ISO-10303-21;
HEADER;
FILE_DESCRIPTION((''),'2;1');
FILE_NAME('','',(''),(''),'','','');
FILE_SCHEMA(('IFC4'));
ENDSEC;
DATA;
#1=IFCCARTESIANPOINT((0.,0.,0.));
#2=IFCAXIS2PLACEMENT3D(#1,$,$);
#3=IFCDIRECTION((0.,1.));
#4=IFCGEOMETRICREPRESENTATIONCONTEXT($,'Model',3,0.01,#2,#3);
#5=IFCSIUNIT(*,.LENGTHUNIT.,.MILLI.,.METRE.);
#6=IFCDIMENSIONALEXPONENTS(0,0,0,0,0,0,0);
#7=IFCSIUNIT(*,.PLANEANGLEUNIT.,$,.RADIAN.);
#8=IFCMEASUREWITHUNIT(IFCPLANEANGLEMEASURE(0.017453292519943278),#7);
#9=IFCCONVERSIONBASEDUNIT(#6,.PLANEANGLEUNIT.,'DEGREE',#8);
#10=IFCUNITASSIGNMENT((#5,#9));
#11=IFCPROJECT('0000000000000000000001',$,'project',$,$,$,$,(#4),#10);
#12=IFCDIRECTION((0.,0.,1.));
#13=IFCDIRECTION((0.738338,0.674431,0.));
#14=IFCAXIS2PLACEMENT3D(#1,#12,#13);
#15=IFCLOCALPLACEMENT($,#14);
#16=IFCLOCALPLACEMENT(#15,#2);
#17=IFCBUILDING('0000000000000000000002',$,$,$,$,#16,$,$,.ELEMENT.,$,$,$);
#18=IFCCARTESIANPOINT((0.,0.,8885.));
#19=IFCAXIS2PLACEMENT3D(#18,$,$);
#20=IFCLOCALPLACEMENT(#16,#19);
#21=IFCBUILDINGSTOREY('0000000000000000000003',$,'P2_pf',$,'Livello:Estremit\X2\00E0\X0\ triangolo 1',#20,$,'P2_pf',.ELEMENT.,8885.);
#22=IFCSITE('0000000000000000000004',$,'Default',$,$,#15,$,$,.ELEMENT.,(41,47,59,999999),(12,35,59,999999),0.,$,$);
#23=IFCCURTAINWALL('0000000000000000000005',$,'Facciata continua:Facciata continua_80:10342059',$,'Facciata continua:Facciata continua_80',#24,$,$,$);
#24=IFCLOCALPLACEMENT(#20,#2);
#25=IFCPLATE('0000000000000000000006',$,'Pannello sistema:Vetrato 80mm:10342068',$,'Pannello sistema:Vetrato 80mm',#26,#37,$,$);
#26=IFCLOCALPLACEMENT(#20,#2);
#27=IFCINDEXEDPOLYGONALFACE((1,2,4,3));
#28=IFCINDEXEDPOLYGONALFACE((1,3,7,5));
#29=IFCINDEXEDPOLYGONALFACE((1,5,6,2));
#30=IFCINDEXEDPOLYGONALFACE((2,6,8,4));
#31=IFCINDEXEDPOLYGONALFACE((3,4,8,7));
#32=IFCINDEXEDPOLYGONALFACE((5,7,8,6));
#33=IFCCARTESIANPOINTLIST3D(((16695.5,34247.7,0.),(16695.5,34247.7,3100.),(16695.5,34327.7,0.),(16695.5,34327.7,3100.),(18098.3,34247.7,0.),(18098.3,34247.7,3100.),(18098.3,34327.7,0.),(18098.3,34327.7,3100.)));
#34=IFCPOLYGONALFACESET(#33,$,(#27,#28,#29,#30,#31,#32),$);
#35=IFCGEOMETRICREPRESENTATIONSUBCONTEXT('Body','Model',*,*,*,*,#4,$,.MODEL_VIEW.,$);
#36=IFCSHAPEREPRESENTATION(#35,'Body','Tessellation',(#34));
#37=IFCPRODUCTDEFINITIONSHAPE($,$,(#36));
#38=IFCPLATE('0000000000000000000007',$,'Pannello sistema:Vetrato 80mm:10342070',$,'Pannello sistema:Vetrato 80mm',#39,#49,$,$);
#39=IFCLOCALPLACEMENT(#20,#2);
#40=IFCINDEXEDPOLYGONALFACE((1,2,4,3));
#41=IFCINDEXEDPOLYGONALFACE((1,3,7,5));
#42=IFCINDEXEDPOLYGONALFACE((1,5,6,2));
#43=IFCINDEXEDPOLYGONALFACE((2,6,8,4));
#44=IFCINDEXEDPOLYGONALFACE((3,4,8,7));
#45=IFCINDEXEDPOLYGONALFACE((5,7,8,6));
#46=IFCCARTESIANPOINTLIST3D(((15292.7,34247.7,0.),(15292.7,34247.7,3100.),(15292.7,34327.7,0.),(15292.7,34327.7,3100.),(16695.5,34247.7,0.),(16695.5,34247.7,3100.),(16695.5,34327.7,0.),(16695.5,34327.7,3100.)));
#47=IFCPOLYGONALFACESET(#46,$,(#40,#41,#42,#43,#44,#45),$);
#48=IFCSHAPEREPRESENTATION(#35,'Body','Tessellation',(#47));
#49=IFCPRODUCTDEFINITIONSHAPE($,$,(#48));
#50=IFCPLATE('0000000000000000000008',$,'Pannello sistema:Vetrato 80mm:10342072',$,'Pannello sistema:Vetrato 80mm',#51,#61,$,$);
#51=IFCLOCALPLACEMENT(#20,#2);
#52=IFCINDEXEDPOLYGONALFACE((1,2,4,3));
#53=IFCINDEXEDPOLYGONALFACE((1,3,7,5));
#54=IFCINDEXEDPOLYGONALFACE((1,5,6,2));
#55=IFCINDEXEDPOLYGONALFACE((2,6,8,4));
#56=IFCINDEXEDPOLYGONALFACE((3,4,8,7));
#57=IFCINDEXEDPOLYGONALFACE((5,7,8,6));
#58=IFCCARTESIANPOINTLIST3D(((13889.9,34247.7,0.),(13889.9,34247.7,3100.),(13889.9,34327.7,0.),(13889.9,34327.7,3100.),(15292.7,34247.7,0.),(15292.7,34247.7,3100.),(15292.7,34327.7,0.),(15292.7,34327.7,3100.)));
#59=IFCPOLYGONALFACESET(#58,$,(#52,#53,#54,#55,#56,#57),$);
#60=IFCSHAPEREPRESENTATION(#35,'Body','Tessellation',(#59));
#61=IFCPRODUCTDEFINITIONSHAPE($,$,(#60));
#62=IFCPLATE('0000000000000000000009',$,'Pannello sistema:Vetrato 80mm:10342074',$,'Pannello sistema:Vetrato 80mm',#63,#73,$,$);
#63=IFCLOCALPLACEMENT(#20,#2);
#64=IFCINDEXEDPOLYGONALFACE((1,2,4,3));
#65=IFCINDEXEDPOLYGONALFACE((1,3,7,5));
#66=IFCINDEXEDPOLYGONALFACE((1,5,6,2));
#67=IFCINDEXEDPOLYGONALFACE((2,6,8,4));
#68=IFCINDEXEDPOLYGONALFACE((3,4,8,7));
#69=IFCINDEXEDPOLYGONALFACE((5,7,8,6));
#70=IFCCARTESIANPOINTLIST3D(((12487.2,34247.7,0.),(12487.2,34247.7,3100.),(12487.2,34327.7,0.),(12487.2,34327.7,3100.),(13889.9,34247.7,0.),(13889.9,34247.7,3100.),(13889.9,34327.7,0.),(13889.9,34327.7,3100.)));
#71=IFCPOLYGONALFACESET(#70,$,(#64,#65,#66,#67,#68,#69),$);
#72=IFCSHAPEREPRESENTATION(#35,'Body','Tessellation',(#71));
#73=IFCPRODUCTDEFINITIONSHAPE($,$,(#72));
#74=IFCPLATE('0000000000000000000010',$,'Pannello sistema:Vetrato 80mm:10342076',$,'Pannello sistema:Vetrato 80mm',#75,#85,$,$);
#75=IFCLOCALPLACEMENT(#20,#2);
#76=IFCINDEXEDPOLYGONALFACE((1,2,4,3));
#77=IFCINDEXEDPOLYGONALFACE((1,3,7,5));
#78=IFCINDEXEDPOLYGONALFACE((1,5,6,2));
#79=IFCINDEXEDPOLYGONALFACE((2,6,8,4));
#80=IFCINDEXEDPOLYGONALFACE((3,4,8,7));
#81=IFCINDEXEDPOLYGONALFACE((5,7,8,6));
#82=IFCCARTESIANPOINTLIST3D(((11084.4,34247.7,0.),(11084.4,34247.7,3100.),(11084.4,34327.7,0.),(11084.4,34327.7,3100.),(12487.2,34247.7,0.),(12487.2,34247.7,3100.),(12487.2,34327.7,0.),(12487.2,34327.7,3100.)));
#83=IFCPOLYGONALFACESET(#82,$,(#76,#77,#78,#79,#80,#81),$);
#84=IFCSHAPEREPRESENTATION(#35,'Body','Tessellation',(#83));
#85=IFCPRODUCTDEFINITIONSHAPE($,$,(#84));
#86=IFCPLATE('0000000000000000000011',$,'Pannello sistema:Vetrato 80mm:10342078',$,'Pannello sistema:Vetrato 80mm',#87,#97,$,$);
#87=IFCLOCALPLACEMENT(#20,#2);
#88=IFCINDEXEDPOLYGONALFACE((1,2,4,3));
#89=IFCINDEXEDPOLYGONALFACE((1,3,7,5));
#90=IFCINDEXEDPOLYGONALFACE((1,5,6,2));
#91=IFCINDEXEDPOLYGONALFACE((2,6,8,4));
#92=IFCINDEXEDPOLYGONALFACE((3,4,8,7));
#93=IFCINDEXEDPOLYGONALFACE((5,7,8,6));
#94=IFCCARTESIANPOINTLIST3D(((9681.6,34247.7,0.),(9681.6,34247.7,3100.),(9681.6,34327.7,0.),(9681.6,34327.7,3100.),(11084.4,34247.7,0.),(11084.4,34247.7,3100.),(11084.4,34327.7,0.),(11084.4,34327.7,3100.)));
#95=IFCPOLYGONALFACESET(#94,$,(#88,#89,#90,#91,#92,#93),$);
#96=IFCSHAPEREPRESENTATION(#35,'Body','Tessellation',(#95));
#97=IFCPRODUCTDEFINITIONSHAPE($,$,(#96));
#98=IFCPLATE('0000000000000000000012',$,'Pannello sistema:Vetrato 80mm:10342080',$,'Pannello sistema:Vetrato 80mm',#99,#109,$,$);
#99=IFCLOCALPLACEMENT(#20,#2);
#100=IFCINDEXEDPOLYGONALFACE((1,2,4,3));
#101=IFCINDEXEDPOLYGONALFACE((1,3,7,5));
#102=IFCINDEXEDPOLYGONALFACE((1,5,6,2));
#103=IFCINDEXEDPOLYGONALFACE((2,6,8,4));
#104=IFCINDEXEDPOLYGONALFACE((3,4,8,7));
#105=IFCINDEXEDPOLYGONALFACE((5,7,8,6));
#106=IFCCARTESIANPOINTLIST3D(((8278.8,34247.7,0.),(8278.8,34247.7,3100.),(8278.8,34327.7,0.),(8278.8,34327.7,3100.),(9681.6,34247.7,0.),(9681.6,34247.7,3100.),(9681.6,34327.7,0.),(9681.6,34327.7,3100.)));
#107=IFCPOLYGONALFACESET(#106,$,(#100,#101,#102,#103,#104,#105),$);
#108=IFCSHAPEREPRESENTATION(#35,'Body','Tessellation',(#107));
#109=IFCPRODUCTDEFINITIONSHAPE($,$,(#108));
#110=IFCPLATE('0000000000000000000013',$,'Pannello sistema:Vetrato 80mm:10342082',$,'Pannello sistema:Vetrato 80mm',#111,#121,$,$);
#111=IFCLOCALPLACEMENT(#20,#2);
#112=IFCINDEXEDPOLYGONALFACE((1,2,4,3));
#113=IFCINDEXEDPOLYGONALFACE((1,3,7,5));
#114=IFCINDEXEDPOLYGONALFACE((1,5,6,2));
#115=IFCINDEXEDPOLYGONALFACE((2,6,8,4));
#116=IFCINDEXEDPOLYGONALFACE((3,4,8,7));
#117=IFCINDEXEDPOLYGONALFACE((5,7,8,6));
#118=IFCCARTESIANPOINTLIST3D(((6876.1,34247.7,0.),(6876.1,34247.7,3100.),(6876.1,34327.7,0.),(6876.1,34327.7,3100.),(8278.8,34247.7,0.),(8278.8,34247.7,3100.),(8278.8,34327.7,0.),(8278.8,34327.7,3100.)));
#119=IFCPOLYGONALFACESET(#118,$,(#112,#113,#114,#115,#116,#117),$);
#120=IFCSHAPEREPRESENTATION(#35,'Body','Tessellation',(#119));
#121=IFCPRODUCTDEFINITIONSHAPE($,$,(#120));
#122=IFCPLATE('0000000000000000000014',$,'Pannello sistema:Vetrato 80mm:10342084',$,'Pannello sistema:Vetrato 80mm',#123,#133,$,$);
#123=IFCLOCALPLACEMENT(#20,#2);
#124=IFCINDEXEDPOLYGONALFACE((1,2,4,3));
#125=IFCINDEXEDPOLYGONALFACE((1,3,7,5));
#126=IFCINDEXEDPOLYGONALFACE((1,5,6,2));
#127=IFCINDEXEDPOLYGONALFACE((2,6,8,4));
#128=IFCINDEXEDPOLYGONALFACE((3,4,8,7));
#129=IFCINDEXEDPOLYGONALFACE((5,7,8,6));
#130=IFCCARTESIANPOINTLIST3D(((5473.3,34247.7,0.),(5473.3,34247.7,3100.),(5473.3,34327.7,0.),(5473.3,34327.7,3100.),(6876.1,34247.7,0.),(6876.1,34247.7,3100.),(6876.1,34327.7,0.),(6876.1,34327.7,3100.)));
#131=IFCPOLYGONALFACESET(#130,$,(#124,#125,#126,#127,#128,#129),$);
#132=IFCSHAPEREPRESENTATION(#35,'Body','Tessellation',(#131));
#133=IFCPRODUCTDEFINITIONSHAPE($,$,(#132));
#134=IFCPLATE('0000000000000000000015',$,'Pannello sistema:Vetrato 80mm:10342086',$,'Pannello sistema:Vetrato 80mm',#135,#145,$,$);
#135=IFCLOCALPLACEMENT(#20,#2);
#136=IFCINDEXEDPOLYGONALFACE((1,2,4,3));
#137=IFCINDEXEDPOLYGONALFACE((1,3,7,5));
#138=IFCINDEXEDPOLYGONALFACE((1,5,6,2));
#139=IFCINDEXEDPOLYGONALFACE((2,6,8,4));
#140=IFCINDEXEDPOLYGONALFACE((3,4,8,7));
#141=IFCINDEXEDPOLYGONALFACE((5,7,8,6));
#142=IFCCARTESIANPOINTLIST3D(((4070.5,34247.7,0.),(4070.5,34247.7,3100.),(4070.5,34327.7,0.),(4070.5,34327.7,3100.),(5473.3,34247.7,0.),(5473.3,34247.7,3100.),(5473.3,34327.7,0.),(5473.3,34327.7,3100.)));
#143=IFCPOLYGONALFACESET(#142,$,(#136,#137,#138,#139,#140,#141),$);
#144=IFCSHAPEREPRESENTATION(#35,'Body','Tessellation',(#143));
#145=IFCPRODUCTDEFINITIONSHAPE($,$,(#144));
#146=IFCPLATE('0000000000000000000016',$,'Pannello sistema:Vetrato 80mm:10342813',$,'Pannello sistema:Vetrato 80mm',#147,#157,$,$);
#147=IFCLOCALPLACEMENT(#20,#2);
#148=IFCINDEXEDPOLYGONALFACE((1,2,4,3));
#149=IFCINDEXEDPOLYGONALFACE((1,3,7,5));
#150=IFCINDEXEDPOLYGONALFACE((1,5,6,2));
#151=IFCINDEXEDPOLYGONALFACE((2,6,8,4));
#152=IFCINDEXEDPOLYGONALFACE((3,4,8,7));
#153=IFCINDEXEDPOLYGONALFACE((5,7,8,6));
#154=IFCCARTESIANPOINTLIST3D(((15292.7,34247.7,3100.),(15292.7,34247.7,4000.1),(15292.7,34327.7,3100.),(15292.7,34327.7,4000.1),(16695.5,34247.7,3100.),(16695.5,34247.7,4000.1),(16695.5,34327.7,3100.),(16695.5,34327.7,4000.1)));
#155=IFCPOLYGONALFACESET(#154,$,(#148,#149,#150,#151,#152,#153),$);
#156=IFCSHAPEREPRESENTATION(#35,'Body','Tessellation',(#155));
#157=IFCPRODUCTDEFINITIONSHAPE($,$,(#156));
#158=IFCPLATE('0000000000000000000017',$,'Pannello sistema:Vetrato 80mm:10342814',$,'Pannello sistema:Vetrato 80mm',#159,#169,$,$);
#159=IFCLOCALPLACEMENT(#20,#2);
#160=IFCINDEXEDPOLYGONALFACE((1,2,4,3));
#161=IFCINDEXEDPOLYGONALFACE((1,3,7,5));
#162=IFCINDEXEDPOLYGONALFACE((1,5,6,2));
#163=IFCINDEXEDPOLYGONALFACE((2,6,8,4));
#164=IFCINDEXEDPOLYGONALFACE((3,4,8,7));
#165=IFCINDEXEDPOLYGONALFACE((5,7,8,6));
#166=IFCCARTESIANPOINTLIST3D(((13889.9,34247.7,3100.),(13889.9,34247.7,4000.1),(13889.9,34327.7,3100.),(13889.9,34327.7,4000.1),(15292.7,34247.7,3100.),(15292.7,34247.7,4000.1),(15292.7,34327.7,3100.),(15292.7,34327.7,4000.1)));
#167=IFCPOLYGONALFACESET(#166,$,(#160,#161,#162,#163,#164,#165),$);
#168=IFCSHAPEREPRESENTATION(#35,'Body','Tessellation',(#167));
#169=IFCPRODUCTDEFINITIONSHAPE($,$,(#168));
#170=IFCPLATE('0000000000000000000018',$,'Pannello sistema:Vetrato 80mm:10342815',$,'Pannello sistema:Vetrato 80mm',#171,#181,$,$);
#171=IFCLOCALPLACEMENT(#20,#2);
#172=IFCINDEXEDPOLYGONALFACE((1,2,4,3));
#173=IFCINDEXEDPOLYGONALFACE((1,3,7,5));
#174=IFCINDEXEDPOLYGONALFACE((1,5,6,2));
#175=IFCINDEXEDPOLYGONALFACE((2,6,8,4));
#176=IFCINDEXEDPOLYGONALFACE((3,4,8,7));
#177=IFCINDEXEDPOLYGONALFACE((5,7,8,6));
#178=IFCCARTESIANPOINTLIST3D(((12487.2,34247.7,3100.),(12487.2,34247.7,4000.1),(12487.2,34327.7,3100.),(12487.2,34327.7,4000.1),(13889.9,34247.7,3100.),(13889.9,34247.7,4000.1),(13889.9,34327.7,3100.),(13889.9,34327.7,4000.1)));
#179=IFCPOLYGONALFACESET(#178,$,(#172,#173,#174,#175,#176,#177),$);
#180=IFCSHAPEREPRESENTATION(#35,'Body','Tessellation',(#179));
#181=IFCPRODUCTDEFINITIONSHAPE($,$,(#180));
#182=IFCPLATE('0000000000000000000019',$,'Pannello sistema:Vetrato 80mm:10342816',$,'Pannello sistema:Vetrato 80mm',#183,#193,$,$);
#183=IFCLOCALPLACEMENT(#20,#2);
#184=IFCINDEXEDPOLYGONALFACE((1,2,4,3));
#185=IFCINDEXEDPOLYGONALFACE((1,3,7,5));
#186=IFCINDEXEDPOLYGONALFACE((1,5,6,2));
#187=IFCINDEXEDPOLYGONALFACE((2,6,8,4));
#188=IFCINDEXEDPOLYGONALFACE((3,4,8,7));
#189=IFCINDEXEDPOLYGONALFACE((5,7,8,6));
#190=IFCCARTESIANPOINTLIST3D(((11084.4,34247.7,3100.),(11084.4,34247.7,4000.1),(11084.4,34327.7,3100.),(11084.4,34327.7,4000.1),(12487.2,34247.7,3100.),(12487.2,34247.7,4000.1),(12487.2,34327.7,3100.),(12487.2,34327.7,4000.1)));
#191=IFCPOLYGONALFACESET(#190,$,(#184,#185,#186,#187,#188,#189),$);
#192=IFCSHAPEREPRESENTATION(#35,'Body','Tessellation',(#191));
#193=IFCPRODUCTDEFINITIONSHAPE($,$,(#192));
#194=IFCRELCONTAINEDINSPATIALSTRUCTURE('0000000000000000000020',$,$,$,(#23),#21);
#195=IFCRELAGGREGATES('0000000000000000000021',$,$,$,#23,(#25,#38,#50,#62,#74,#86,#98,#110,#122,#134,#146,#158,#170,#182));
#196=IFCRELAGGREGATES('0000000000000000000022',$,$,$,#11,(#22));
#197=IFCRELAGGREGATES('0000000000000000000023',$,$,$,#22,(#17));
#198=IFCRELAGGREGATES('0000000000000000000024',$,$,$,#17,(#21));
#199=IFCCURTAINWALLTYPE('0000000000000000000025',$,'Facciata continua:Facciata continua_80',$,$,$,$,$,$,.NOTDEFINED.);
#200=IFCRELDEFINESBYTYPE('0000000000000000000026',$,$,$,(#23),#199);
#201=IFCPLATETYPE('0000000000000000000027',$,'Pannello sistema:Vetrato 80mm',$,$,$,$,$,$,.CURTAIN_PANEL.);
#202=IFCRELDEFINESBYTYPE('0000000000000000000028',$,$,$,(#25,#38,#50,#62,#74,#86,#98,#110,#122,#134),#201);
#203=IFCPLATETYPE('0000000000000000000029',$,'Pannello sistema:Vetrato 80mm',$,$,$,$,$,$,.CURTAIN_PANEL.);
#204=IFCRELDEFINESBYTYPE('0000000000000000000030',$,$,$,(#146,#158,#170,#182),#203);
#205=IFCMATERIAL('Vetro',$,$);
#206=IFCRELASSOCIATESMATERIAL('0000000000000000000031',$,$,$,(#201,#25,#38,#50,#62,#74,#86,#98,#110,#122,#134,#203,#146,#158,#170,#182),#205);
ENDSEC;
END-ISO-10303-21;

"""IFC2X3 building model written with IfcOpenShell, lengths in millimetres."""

from ifc_helpers import new_model, entity, si_unit, converted_unit, direction, frame, origin, origin_2d_with_axis, place, context, subcontext, project, spatial, rectangle, extrude, source, transform, mapped, material, type_object, type_shapes, element, aggregate, save


model = new_model("IFC2X3")

# Units and contexts
model_context = context("Model", 3, precision=0.01, world=origin(), true_north=direction((0.0, 1.0)))
body_context = subcontext(model_context, "Body", "Model", "MODEL_VIEW")
ifc_project = project(units=[si_unit("LENGTHUNIT", "METRE", prefix="MILLI"), converted_unit("PLANEANGLEUNIT", "DEGREE", entity("IfcPlaneAngleMeasure", 0.017453292519943278), si_unit("PLANEANGLEUNIT", "RADIAN"), dimensions=[0, 0, 0, 0, 0, 0, 0])], contexts=[model_context])

# Site, building, storey
site_placement = place(None, frame((0.0, 0.0, 0.0), z_axis=(0.0, 0.0, 1.0), x_axis=(0.738338, 0.674431, 0.0)))
site = spatial("IfcSite", under=ifc_project, at=site_placement, Name="Default", CompositionType="ELEMENT", RefLatitude=(41, 47, 59, 999999), RefLongitude=(12, 35, 59, 999999), RefElevation=0.0)
building_placement = place(site_placement, origin())
building = spatial("IfcBuilding", under=site, at=building_placement, CompositionType="ELEMENT")
storey_placement = place(building_placement, frame((0.0, 0.0, 8885.0)))
storey = spatial("IfcBuildingStorey", under=building, at=storey_placement, Name="P2_pf", ObjectType="Livello:Estremità triangolo 1", LongName="P2_pf", CompositionType="ELEMENT", Elevation=8885.0)

# Curtain wall, plates
curtain_wall_type = type_object("IfcCurtainWallType", Name="Facciata continua:Facciata continua_80", PredefinedType="NOTDEFINED")
curtain_wall_1_placement = place(storey_placement, frame((0.0, 0.0, -8885.0)))
curtain_wall_1 = element("IfcCurtainWall", 1, at=curtain_wall_1_placement, inside=storey, type_object=curtain_wall_type, Name="Facciata continua:Facciata continua_80:10342059", ObjectType="Facciata continua:Facciata continua_80")
ifc_material_1 = material(Name="Vetro")
plate_type_1 = type_object("IfcPlateType", Name="Pannello sistema:Vetrato 80mm", PredefinedType="CURTAIN_PANEL", material=ifc_material_1)
shared_shape_1 = source(origin(), body_context, "Body", "SweptSolid", [
    extrude(rectangle(XDim=80.0, YDim=1402.8, at=origin_2d_with_axis()), frame((0.0, -40.0, 0.0), z_axis=(0.0, 0.0, 1.0), x_axis=(0.0, 1.0, 0.0)), (0.0, 0.0, 1.0), 3100.0),
])
type_shapes(plate_type_1, [shared_shape_1])
plate_1_placement = place(curtain_wall_1_placement, frame((17396.9, 34247.7, 8885.0), z_axis=(0.0, 0.0, 1.0), x_axis=(-1.0, 0.0, 0.0)))
plate_1 = element("IfcPlate", 2, at=plate_1_placement, type_object=plate_type_1, material=ifc_material_1, Name="Pannello sistema:Vetrato 80mm:10342068", ObjectType="Pannello sistema:Vetrato 80mm", context=body_context, shape_type="MappedRepresentation", body=[
    mapped(shared_shape_1, transform((0.0, 0.0, 0.0), scale=1.0)),
])
plate_2_placement = place(curtain_wall_1_placement, frame((15994.1, 34247.7, 8885.0), z_axis=(0.0, 0.0, 1.0), x_axis=(-1.0, 0.0, 0.0)))
plate_2 = element("IfcPlate", 3, at=plate_2_placement, type_object=plate_type_1, material=ifc_material_1, Name="Pannello sistema:Vetrato 80mm:10342070", ObjectType="Pannello sistema:Vetrato 80mm", context=body_context, shape_type="MappedRepresentation", body=[
    mapped(shared_shape_1, transform((0.0, 0.0, 0.0), scale=1.0)),
])
plate_3_placement = place(curtain_wall_1_placement, frame((14591.3, 34247.7, 8885.0), z_axis=(0.0, 0.0, 1.0), x_axis=(-1.0, 0.0, 0.0)))
plate_3 = element("IfcPlate", 4, at=plate_3_placement, type_object=plate_type_1, material=ifc_material_1, Name="Pannello sistema:Vetrato 80mm:10342072", ObjectType="Pannello sistema:Vetrato 80mm", context=body_context, shape_type="MappedRepresentation", body=[
    mapped(shared_shape_1, transform((0.0, 0.0, 0.0), scale=1.0)),
])
plate_4_placement = place(curtain_wall_1_placement, frame((13188.5, 34247.7, 8885.0), z_axis=(0.0, 0.0, 1.0), x_axis=(-1.0, 0.0, 0.0)))
plate_4 = element("IfcPlate", 5, at=plate_4_placement, type_object=plate_type_1, material=ifc_material_1, Name="Pannello sistema:Vetrato 80mm:10342074", ObjectType="Pannello sistema:Vetrato 80mm", context=body_context, shape_type="MappedRepresentation", body=[
    mapped(shared_shape_1, transform((0.0, 0.0, 0.0), scale=1.0)),
])
plate_5_placement = place(curtain_wall_1_placement, frame((11785.8, 34247.7, 8885.0), z_axis=(0.0, 0.0, 1.0), x_axis=(-1.0, 0.0, 0.0)))
plate_5 = element("IfcPlate", 6, at=plate_5_placement, type_object=plate_type_1, material=ifc_material_1, Name="Pannello sistema:Vetrato 80mm:10342076", ObjectType="Pannello sistema:Vetrato 80mm", context=body_context, shape_type="MappedRepresentation", body=[
    mapped(shared_shape_1, transform((0.0, 0.0, 0.0), scale=1.0)),
])
plate_6_placement = place(curtain_wall_1_placement, frame((10383.0, 34247.7, 8885.0), z_axis=(0.0, 0.0, 1.0), x_axis=(-1.0, 0.0, 0.0)))
plate_6 = element("IfcPlate", 7, at=plate_6_placement, type_object=plate_type_1, material=ifc_material_1, Name="Pannello sistema:Vetrato 80mm:10342078", ObjectType="Pannello sistema:Vetrato 80mm", context=body_context, shape_type="MappedRepresentation", body=[
    mapped(shared_shape_1, transform((0.0, 0.0, 0.0), scale=1.0)),
])
plate_7_placement = place(curtain_wall_1_placement, frame((8980.2, 34247.7, 8885.0), z_axis=(0.0, 0.0, 1.0), x_axis=(-1.0, 0.0, 0.0)))
plate_7 = element("IfcPlate", 8, at=plate_7_placement, type_object=plate_type_1, material=ifc_material_1, Name="Pannello sistema:Vetrato 80mm:10342080", ObjectType="Pannello sistema:Vetrato 80mm", context=body_context, shape_type="MappedRepresentation", body=[
    mapped(shared_shape_1, transform((0.0, 0.0, 0.0), scale=1.0)),
])
plate_8_placement = place(curtain_wall_1_placement, frame((7577.4, 34247.7, 8885.0), z_axis=(0.0, 0.0, 1.0), x_axis=(-1.0, 0.0, 0.0)))
plate_8 = element("IfcPlate", 9, at=plate_8_placement, type_object=plate_type_1, material=ifc_material_1, Name="Pannello sistema:Vetrato 80mm:10342082", ObjectType="Pannello sistema:Vetrato 80mm", context=body_context, shape_type="MappedRepresentation", body=[
    mapped(shared_shape_1, transform((0.0, 0.0, 0.0), scale=1.0)),
])
plate_9_placement = place(curtain_wall_1_placement, frame((6174.7, 34247.7, 8885.0), z_axis=(0.0, 0.0, 1.0), x_axis=(-1.0, 0.0, 0.0)))
plate_9 = element("IfcPlate", 10, at=plate_9_placement, type_object=plate_type_1, material=ifc_material_1, Name="Pannello sistema:Vetrato 80mm:10342084", ObjectType="Pannello sistema:Vetrato 80mm", context=body_context, shape_type="MappedRepresentation", body=[
    mapped(shared_shape_1, transform((0.0, 0.0, 0.0), scale=1.0)),
])
plate_10_placement = place(curtain_wall_1_placement, frame((4771.9, 34247.7, 8885.0), z_axis=(0.0, 0.0, 1.0), x_axis=(-1.0, 0.0, 0.0)))
plate_10 = element("IfcPlate", 11, at=plate_10_placement, type_object=plate_type_1, material=ifc_material_1, Name="Pannello sistema:Vetrato 80mm:10342086", ObjectType="Pannello sistema:Vetrato 80mm", context=body_context, shape_type="MappedRepresentation", body=[
    mapped(shared_shape_1, transform((0.0, 0.0, 0.0), scale=1.0)),
])
plate_type_2 = type_object("IfcPlateType", Name="Pannello sistema:Vetrato 80mm", PredefinedType="CURTAIN_PANEL", material=ifc_material_1)
shared_shape_2 = source(origin(), body_context, "Body", "SweptSolid", [
    extrude(rectangle(XDim=80.0, YDim=1402.8, at=origin_2d_with_axis()), frame((0.0, -40.0, 0.0), z_axis=(0.0, 0.0, 1.0), x_axis=(0.0, 1.0, 0.0)), (0.0, 0.0, 1.0), 900.1),
])
type_shapes(plate_type_2, [shared_shape_2])
plate_11_placement = place(curtain_wall_1_placement, frame((15994.1, 34247.7, 11985.0), z_axis=(0.0, 0.0, 1.0), x_axis=(-1.0, 0.0, 0.0)))
plate_11 = element("IfcPlate", 12, at=plate_11_placement, type_object=plate_type_2, material=ifc_material_1, Name="Pannello sistema:Vetrato 80mm:10342813", ObjectType="Pannello sistema:Vetrato 80mm", context=body_context, shape_type="MappedRepresentation", body=[
    mapped(shared_shape_2, transform((0.0, 0.0, 0.0), scale=1.0)),
])
plate_12_placement = place(curtain_wall_1_placement, frame((14591.3, 34247.7, 11985.0), z_axis=(0.0, 0.0, 1.0), x_axis=(-1.0, 0.0, 0.0)))
plate_12 = element("IfcPlate", 13, at=plate_12_placement, type_object=plate_type_2, material=ifc_material_1, Name="Pannello sistema:Vetrato 80mm:10342814", ObjectType="Pannello sistema:Vetrato 80mm", context=body_context, shape_type="MappedRepresentation", body=[
    mapped(shared_shape_2, transform((0.0, 0.0, 0.0), scale=1.0)),
])
plate_13_placement = place(curtain_wall_1_placement, frame((13188.5, 34247.7, 11985.0), z_axis=(0.0, 0.0, 1.0), x_axis=(-1.0, 0.0, 0.0)))
plate_13 = element("IfcPlate", 14, at=plate_13_placement, type_object=plate_type_2, material=ifc_material_1, Name="Pannello sistema:Vetrato 80mm:10342815", ObjectType="Pannello sistema:Vetrato 80mm", context=body_context, shape_type="MappedRepresentation", body=[
    mapped(shared_shape_2, transform((0.0, 0.0, 0.0), scale=1.0)),
])
plate_14_placement = place(curtain_wall_1_placement, frame((11785.8, 34247.7, 11985.0), z_axis=(0.0, 0.0, 1.0), x_axis=(-1.0, 0.0, 0.0)))
plate_14 = element("IfcPlate", 15, at=plate_14_placement, type_object=plate_type_2, material=ifc_material_1, Name="Pannello sistema:Vetrato 80mm:10342816", ObjectType="Pannello sistema:Vetrato 80mm", context=body_context, shape_type="MappedRepresentation", body=[
    mapped(shared_shape_2, transform((0.0, 0.0, 0.0), scale=1.0)),
])
aggregate(curtain_wall_1, [plate_1, plate_2, plate_3, plate_4, plate_5, plate_6, plate_7, plate_8, plate_9, plate_10, plate_11, plate_12, plate_13, plate_14])

save(model, "model.ifc")
